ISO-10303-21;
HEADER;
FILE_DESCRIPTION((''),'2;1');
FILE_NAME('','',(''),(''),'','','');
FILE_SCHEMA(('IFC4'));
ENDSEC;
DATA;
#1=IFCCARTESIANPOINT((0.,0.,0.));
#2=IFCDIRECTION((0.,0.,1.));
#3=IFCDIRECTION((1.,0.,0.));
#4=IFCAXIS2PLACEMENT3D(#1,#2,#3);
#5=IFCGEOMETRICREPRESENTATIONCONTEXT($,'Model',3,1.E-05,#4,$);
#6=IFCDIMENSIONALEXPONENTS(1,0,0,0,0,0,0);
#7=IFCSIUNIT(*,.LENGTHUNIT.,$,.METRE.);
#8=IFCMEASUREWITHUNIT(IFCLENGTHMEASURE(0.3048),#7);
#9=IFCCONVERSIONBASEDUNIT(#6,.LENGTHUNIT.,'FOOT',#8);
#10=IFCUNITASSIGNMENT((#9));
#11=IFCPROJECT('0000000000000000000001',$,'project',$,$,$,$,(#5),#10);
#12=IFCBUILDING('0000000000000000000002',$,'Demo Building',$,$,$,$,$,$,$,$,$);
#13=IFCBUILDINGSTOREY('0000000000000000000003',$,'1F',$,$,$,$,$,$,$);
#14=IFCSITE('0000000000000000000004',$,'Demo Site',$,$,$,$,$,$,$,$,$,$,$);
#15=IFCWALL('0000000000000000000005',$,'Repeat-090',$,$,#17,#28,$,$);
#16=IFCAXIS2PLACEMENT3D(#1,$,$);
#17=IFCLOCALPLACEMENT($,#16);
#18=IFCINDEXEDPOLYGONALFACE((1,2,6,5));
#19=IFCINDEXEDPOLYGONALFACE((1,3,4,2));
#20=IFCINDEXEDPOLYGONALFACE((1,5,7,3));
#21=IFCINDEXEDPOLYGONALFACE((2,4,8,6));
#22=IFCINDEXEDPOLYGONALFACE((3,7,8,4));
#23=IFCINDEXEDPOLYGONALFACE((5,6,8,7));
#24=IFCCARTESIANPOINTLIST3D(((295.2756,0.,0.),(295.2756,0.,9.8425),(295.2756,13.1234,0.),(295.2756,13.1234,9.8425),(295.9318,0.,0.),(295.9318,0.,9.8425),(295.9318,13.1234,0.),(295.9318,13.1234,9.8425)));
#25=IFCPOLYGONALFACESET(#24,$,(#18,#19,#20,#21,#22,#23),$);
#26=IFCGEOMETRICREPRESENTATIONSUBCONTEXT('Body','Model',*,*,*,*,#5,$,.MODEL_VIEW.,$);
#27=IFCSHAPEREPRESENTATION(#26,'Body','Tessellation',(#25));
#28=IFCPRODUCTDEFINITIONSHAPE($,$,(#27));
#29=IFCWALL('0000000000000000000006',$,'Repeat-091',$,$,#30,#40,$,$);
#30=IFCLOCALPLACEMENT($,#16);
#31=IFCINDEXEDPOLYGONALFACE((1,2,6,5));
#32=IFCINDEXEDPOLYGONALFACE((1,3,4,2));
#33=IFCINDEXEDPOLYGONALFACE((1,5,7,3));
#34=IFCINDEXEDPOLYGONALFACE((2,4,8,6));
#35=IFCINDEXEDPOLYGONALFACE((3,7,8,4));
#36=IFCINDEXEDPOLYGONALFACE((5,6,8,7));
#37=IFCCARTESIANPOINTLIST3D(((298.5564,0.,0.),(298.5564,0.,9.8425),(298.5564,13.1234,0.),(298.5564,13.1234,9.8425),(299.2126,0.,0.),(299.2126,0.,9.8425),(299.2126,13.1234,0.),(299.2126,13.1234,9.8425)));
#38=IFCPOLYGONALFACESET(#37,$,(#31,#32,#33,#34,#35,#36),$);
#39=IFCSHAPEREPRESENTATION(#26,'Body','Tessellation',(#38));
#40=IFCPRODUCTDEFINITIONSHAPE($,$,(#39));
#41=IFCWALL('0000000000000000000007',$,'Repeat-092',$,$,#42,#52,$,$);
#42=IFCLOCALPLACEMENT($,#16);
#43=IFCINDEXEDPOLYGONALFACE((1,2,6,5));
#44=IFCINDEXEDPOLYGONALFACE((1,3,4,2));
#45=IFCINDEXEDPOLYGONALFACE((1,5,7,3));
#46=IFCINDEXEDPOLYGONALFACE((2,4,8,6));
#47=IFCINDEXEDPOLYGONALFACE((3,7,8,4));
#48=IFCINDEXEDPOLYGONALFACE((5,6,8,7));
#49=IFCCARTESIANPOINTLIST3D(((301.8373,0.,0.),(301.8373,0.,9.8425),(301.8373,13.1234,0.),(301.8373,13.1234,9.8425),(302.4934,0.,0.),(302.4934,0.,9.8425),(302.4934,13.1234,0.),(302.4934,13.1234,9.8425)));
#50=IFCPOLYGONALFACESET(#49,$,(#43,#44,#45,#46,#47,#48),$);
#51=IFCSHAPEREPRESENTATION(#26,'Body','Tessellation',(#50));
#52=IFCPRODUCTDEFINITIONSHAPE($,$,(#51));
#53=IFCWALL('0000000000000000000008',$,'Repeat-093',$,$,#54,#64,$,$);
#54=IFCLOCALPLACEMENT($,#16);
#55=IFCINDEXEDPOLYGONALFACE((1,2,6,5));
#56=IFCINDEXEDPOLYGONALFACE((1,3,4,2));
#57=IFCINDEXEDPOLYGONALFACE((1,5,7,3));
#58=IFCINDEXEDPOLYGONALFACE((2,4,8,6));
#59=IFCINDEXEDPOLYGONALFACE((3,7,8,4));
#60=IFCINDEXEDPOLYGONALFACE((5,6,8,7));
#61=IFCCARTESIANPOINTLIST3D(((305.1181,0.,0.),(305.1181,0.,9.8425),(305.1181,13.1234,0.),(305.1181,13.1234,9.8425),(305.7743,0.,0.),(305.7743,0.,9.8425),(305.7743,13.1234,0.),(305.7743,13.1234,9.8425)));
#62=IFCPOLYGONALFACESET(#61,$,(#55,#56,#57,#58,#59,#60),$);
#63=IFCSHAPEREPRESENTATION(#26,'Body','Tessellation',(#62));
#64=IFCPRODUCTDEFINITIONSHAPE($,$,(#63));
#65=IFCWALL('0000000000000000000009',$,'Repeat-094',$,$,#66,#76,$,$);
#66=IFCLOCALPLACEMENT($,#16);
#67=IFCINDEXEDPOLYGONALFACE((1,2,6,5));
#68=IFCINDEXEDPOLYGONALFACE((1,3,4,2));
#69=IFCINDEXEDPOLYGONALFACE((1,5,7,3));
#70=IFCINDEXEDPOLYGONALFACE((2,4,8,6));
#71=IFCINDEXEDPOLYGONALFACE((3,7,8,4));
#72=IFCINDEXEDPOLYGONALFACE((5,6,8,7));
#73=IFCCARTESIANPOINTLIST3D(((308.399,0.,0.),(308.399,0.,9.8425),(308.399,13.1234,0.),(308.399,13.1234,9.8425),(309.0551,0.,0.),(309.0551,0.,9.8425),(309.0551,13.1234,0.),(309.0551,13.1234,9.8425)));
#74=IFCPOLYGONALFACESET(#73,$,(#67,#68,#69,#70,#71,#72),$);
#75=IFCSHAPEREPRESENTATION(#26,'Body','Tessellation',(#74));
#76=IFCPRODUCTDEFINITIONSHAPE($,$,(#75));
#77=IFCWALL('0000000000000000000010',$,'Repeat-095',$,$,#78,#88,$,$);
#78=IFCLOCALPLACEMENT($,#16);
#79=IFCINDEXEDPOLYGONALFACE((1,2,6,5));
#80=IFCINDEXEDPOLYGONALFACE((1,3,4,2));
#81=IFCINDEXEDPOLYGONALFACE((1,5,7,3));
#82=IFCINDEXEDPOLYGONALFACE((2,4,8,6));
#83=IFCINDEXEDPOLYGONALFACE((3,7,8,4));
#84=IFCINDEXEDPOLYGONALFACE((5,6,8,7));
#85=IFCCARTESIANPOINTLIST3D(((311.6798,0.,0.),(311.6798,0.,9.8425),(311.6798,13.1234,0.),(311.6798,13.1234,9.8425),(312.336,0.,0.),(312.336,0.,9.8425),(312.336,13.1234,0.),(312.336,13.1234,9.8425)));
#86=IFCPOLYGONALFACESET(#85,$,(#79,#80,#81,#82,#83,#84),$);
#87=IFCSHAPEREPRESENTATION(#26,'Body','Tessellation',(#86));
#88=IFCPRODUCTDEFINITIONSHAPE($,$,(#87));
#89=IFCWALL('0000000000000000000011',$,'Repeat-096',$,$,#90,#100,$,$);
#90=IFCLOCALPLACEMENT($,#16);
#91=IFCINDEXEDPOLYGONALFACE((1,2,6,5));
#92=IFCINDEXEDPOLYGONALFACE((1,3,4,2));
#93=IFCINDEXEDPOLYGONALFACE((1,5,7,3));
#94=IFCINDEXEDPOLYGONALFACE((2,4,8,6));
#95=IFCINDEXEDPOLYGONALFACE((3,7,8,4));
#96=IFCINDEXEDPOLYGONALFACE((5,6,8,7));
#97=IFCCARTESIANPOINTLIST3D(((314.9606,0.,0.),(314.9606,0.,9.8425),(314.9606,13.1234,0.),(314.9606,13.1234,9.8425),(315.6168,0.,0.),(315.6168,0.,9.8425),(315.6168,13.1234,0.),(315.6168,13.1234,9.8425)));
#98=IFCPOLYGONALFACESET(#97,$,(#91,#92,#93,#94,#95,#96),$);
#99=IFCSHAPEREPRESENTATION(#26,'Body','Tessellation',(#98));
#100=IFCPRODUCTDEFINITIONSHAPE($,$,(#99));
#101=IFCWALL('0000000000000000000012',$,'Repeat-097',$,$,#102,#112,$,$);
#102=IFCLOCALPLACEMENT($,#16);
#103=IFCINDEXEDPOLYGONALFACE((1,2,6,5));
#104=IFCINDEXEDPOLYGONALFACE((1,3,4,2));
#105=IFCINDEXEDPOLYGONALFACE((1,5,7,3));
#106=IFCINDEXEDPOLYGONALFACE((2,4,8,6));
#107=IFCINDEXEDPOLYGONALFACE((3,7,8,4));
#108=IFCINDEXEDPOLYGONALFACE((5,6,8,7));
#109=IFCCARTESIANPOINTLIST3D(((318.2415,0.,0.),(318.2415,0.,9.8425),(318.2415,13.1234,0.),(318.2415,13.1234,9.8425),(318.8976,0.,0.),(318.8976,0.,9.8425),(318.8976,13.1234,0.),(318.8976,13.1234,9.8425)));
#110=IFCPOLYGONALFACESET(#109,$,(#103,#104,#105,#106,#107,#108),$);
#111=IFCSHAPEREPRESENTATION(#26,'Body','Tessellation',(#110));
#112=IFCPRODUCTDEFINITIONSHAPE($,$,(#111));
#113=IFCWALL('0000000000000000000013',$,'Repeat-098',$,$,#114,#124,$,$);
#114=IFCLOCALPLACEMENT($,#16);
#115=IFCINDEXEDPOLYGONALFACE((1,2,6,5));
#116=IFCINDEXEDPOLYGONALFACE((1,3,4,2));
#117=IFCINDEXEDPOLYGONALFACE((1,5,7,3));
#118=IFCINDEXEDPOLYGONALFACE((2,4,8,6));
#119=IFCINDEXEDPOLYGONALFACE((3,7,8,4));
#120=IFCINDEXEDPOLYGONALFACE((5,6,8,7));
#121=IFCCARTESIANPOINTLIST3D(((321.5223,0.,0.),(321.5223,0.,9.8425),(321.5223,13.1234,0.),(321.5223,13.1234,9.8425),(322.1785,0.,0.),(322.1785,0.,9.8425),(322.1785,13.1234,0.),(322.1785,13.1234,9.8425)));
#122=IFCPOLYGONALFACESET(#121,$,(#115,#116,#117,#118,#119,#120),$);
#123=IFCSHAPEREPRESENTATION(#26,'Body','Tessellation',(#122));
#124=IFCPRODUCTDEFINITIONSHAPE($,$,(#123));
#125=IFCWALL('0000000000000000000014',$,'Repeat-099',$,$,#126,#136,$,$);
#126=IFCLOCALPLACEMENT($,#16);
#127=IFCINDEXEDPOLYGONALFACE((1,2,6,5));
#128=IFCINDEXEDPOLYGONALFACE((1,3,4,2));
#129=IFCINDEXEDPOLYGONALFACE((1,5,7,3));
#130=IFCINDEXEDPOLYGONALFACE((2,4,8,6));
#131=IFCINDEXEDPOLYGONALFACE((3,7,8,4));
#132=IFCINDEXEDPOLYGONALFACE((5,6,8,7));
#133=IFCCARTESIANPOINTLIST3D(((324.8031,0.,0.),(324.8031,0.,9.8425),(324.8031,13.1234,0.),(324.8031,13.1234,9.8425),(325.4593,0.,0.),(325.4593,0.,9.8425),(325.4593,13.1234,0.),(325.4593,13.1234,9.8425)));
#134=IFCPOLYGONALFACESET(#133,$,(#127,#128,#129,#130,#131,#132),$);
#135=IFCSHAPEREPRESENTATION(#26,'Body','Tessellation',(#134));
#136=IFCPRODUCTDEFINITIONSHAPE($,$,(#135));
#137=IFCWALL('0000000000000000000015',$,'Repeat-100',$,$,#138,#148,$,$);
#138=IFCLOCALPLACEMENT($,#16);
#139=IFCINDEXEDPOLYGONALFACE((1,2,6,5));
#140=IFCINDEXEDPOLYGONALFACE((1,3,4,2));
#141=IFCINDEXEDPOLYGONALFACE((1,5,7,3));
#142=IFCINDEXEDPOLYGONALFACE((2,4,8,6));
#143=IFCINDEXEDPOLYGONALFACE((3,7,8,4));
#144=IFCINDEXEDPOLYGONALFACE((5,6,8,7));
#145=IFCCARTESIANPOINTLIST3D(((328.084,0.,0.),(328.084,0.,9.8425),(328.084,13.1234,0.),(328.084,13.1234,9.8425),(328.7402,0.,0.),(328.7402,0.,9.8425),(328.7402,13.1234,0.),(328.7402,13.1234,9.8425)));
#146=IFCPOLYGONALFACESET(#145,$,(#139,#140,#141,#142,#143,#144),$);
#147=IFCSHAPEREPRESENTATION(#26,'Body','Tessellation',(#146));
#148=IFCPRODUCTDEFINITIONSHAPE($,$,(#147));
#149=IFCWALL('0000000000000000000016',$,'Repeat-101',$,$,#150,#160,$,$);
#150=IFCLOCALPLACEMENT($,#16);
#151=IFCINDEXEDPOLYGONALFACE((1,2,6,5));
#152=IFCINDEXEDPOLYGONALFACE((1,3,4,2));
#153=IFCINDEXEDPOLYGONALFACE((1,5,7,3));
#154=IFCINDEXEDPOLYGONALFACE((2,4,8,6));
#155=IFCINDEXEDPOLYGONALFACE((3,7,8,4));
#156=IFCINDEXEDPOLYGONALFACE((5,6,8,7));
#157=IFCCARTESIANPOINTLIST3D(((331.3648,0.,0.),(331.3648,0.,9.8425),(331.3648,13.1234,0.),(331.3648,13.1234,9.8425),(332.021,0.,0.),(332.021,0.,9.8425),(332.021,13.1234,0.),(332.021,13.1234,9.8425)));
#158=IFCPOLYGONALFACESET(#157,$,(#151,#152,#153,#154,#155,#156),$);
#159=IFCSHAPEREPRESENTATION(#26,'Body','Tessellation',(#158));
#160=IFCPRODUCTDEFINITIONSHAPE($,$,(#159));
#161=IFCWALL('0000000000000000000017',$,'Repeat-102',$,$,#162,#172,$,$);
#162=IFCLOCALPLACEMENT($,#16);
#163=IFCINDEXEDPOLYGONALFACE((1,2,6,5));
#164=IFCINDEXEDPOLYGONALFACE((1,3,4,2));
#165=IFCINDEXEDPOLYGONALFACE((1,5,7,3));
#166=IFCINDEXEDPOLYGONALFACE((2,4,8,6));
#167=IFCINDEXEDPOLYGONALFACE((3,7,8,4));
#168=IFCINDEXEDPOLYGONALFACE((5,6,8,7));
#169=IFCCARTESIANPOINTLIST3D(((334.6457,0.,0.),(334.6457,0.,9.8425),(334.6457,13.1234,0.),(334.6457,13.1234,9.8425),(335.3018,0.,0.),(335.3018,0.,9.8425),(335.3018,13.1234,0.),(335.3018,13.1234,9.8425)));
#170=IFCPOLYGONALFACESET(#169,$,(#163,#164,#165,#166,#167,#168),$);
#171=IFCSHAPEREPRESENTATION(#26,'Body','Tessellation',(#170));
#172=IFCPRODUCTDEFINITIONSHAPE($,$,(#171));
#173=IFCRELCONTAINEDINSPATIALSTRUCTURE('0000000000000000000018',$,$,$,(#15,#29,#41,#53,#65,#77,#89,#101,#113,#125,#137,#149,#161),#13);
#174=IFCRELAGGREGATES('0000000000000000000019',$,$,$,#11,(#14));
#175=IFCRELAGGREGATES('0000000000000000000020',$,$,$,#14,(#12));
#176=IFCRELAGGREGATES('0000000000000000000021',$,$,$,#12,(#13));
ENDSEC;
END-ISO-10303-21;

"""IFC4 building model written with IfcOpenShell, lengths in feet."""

from ifc_helpers import new_model, entity, si_unit, converted_unit, frame, origin_with_axes, place, context, subcontext, project, spatial, element, save


model = new_model("IFC4")

# Units and contexts
model_context = context("Model", 3, precision=1e-05, world=origin_with_axes())
body_context = subcontext(model_context, "Body", "Model", "MODEL_VIEW")
ifc_project = project(units=[converted_unit("LENGTHUNIT", "FOOT", entity("IfcLengthMeasure", 0.3048), si_unit("LENGTHUNIT", "METRE"), dimensions=[1, 0, 0, 0, 0, 0, 0])], contexts=[model_context])

# Site, building, storey
site = spatial("IfcSite", under=ifc_project, Name="Demo Site")
building = spatial("IfcBuilding", under=site, Name="Demo Building")
storey = spatial("IfcBuildingStorey", under=building, Name="1F")

# Walls
for number, where, z_axis, x_axis, name in (
    (1, (295.2756, 0.0, 0.0), (0.0, 0.0, 1.0), (1.0, 0.0, 0.0), "Repeat-090"),
    (2, (298.5564, 0.0, 0.0), (0.0, 0.0, 1.0), (1.0, 0.0, 0.0), "Repeat-091"),
    (3, (301.8373, 0.0, 0.0), (0.0, 0.0, 1.0), (1.0, 0.0, 0.0), "Repeat-092"),
    (4, (305.1181, 0.0, 0.0), (0.0, 0.0, 1.0), (1.0, 0.0, 0.0), "Repeat-093"),
    (5, (308.399, 0.0, 0.0), (0.0, 0.0, 1.0), (1.0, 0.0, 0.0), "Repeat-094"),
    (6, (311.6798, 0.0, 0.0), (0.0, 0.0, 1.0), (1.0, 0.0, 0.0), "Repeat-095"),
    (7, (314.9606, 0.0, 0.0), (0.0, 0.0, 1.0), (1.0, 0.0, 0.0), "Repeat-096"),
    (8, (318.2415, 0.0, 0.0), (0.0, 0.0, 1.0), (1.0, 0.0, 0.0), "Repeat-097"),
    (9, (321.5223, 0.0, 0.0), (0.0, 0.0, 1.0), (1.0, 0.0, 0.0), "Repeat-098"),
    (10, (324.8031, 0.0, 0.0), (0.0, 0.0, 1.0), (1.0, 0.0, 0.0), "Repeat-099"),
    (11, (328.084, 0.0, 0.0), (0.0, 0.0, 1.0), (1.0, 0.0, 0.0), "Repeat-100"),
    (12, (331.3648, 0.0, 0.0), (0.0, 0.0, 1.0), (1.0, 0.0, 0.0), "Repeat-101"),
    (13, (334.6457, 0.0, 0.0), (0.0, 0.0, 1.0), (1.0, 0.0, 0.0), "Repeat-102"),
):
    element("IfcWall", number, at=place(None, frame(where, z_axis=z_axis, x_axis=x_axis)), inside=storey, Name=name, context=body_context, shape_type="CSG", body=[
        entity("IfcBlock", entity("IfcAxis2Placement3D", entity("IfcCartesianPoint", [0.0, 0.0, 0.0]), entity("IfcDirection", [0.0, 0.0, 1.0]), entity("IfcDirection", [1.0, 0.0, 0.0])), 0.6562, 13.1234, 9.8425),
    ])

save(model, "model.ifc")
